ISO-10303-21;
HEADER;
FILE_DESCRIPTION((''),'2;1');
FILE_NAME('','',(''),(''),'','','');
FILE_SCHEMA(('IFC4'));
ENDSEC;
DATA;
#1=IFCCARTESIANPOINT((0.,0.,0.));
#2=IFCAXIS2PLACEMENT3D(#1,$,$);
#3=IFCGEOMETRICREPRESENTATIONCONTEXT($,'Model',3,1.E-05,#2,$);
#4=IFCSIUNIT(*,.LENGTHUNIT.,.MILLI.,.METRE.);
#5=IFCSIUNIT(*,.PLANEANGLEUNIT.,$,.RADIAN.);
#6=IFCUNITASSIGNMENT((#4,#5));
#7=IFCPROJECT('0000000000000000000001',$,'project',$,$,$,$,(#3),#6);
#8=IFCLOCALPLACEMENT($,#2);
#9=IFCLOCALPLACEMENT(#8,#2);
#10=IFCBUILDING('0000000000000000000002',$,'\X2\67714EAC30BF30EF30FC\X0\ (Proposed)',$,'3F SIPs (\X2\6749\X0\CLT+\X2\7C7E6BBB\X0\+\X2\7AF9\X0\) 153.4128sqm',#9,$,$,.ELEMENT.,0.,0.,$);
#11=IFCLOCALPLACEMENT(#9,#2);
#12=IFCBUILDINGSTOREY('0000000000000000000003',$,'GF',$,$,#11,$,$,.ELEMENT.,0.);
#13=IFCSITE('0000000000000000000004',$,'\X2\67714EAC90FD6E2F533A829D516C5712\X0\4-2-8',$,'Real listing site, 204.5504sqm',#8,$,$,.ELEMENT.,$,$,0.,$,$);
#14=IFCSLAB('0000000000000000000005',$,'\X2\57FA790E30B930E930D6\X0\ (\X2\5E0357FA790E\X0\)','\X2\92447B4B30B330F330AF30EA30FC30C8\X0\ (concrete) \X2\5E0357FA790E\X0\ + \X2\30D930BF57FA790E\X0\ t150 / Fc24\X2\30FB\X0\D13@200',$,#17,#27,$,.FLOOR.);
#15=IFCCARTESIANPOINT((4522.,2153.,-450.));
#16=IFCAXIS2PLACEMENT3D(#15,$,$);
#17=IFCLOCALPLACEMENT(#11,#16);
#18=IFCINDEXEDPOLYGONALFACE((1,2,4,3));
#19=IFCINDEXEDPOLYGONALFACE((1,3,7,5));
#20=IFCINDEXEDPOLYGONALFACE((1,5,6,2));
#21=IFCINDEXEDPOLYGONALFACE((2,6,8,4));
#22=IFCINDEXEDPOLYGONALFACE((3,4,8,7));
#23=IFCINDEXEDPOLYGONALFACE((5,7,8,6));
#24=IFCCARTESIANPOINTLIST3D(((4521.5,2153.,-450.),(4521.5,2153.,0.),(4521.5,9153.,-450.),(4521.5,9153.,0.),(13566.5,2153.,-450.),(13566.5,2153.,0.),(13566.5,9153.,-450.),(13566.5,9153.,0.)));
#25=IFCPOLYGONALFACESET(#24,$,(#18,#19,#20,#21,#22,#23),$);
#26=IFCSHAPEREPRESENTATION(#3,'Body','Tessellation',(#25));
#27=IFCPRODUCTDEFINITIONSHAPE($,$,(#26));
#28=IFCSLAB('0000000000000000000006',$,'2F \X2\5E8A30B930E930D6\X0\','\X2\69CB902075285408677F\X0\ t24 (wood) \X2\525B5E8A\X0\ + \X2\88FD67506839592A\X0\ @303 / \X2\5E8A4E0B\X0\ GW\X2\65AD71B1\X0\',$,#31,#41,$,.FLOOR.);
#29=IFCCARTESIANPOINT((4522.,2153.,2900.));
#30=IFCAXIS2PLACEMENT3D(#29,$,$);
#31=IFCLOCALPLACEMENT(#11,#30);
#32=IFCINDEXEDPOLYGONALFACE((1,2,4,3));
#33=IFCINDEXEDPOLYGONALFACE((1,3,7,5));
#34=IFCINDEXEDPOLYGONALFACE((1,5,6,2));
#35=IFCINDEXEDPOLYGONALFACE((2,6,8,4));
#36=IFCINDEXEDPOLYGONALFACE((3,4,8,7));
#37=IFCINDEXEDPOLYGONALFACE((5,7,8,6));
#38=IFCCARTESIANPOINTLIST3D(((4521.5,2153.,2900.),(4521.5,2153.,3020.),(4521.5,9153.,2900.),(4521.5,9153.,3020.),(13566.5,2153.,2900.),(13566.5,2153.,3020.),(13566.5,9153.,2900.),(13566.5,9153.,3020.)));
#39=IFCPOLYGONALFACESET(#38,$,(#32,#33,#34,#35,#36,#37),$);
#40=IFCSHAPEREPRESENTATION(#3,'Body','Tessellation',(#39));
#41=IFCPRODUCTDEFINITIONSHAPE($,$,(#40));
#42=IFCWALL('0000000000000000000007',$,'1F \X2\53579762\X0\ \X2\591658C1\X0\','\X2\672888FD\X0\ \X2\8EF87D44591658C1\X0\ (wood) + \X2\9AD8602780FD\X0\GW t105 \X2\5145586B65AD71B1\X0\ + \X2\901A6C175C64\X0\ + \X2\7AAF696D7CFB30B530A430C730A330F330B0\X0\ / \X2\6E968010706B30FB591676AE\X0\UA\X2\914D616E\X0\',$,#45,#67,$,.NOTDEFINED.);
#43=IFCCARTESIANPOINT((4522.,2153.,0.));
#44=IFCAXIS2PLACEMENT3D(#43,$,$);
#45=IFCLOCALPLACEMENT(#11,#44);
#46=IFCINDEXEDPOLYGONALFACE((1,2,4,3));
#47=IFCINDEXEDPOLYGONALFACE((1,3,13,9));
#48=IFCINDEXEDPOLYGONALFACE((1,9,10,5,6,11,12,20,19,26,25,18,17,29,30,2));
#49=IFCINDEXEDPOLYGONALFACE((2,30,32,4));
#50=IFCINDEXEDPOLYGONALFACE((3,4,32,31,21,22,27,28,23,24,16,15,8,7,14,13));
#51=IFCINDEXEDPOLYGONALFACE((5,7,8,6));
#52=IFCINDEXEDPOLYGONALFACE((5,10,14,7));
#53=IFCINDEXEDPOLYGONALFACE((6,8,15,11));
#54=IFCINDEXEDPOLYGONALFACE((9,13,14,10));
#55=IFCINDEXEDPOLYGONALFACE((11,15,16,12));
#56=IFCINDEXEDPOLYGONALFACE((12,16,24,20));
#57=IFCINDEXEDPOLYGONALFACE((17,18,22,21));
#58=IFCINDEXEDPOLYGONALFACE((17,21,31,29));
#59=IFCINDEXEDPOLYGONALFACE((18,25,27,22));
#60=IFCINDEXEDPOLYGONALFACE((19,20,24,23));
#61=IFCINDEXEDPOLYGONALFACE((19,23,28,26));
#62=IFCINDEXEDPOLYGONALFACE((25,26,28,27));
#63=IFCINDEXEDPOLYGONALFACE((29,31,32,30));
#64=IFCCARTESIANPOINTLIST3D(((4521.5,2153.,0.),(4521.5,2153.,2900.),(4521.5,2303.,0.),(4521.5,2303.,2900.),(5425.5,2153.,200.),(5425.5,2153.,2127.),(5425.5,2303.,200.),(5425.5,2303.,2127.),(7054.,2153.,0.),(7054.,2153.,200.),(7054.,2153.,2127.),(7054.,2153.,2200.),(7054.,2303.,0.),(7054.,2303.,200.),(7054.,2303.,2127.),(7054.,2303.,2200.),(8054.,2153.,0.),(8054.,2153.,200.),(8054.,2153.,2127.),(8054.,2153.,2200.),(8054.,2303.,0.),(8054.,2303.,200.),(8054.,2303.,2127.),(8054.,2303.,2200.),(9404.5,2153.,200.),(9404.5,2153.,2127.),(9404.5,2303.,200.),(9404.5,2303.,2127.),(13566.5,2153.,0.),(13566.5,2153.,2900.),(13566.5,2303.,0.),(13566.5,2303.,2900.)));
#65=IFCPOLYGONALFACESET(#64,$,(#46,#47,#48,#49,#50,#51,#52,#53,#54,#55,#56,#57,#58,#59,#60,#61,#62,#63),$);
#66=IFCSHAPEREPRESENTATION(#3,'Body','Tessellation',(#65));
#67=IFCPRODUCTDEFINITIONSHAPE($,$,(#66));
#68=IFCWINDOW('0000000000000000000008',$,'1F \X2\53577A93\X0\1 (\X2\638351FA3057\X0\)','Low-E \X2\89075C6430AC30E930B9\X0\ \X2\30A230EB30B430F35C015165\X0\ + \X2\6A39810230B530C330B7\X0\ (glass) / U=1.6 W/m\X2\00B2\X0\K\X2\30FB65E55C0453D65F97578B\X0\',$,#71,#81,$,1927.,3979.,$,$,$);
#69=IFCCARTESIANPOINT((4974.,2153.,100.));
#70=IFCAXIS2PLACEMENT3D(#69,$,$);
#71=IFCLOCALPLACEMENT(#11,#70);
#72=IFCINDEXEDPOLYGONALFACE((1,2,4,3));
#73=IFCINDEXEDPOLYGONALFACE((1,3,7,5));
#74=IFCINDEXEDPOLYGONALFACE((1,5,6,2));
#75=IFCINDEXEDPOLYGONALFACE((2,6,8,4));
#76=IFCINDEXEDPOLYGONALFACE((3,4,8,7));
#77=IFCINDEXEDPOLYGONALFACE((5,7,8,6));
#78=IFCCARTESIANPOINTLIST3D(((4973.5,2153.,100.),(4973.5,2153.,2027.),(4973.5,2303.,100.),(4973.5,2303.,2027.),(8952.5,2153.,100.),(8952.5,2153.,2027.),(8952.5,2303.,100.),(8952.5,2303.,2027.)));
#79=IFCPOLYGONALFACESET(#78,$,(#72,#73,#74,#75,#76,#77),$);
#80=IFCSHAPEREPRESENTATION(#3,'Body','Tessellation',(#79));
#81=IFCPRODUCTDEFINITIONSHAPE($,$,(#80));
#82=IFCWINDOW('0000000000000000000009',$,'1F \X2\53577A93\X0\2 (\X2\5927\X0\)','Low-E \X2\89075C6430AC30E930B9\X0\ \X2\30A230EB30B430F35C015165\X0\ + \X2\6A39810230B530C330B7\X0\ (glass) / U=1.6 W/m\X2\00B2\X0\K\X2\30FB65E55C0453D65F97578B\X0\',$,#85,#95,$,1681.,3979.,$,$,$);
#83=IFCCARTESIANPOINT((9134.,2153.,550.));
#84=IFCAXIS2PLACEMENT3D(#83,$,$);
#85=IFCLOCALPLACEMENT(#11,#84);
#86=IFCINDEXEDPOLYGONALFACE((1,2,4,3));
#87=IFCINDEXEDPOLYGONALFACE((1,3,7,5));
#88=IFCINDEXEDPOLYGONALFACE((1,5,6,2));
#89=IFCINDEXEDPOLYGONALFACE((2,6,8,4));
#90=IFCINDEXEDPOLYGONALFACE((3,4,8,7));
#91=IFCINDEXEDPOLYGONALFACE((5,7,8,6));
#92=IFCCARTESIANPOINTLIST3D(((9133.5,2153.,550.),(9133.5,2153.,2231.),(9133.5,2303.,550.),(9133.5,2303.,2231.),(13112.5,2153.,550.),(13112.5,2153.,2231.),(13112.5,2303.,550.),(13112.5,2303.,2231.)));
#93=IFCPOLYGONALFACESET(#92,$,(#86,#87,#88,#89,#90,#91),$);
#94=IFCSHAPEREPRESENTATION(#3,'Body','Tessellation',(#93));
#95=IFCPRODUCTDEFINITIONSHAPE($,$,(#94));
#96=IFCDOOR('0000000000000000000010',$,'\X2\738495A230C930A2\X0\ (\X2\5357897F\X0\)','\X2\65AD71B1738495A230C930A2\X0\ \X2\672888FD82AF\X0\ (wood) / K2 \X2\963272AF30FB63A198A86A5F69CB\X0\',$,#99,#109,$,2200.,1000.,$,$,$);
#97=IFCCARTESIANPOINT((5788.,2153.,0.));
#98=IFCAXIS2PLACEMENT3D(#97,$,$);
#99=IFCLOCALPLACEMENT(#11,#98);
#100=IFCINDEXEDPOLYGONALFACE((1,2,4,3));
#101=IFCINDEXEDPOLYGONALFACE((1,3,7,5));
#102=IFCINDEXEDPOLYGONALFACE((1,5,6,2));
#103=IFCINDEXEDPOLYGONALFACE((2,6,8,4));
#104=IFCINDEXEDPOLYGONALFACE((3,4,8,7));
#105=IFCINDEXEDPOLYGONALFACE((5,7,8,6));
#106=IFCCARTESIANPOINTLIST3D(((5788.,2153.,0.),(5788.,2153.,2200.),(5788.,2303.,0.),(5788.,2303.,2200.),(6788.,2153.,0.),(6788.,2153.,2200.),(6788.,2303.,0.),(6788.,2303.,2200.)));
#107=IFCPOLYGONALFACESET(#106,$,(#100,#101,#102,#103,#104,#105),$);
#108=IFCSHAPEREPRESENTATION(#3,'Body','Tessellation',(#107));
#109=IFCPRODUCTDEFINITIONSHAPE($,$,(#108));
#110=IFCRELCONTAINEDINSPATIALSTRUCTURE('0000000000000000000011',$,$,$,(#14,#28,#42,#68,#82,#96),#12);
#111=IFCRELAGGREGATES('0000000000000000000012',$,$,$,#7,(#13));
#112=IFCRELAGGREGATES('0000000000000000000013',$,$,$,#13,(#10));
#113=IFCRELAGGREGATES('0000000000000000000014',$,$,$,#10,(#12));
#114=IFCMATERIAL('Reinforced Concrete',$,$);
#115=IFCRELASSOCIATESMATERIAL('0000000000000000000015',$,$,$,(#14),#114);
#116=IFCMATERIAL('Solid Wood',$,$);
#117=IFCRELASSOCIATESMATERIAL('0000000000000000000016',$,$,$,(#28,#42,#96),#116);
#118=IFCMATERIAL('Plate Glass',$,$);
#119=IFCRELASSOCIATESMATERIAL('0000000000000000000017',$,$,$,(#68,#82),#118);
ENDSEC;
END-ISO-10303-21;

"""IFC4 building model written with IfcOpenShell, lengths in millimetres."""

from ifc_helpers import new_model, si_unit, frame, frame_2d, origin, place, context, project, spatial, rectangle, extrude, material, element, fill, save


model = new_model("IFC4")

# Units and contexts
model_context = context("Model", 3, precision=1e-05, world=origin())
ifc_project = project(units=[si_unit("LENGTHUNIT", "METRE", prefix="MILLI"), si_unit("PLANEANGLEUNIT", "RADIAN")], contexts=[model_context])

# Site, building, storey
site_placement = place(None, origin())
site = spatial("IfcSite", under=ifc_project, at=site_placement, Name="東京都港区芝公園4-2-8", ObjectType="Real listing site, 204.5504sqm", CompositionType="ELEMENT", RefElevation=0.0)
building_placement = place(site_placement, origin())
building = spatial("IfcBuilding", under=site, at=building_placement, Name="東京タワー (Proposed)", ObjectType="3F SIPs (杉CLT+籾殻+竹) 153.4128sqm", CompositionType="ELEMENT", ElevationOfRefHeight=0.0, ElevationOfTerrain=0.0)
storey_placement = place(building_placement, origin())
storey = spatial("IfcBuildingStorey", under=building, at=storey_placement, Name="GF", CompositionType="ELEMENT", Elevation=0.0)

# Slabs
ifc_material_1 = material(Name="Reinforced Concrete")
slab_1_placement = place(storey_placement, frame((4522.0, 2153.0, -450.0)))
element("IfcSlab", 1, at=slab_1_placement, inside=storey, material=ifc_material_1, Name="基礎スラブ (布基礎)", Description="鉄筋コンクリート (concrete) 布基礎 + ベタ基礎 t150 / Fc24・D13@200", PredefinedType="FLOOR", context=model_context, shape_type="SweptSolid", body=[
    extrude(rectangle(XDim=9045.0, YDim=7000.0, at=frame_2d((4522.0, 3500.0))), frame((4522.0, 2153.0, -450.0)), (0.0, 0.0, 1.0), 450.0),
])
ifc_material_2 = material(Name="Solid Wood")
slab_2_placement = place(storey_placement, frame((4522.0, 2153.0, 2900.0)))
element("IfcSlab", 2, at=slab_2_placement, inside=storey, material=ifc_material_2, Name="2F 床スラブ", Description="構造用合板 t24 (wood) 剛床 + 製材根太 @303 / 床下 GW断熱", PredefinedType="FLOOR", context=model_context, shape_type="SweptSolid", body=[
    extrude(rectangle(XDim=9045.0, YDim=7000.0, at=frame_2d((4522.0, 3500.0))), frame((4522.0, 2153.0, 2900.0)), (0.0, 0.0, 1.0), 120.0),
])

# Wall, openings, windows, door
wall_1_placement = place(storey_placement, frame((4522.0, 2153.0, 0.0)))
wall_1 = element("IfcWall", 3, at=wall_1_placement, inside=storey, material=ifc_material_2, Name="1F 南面 外壁", Description="木製 軸組外壁 (wood) + 高性能GW t105 充填断熱 + 通気層 + 窯業系サイディング / 準耐火・外皮UA配慮", PredefinedType="NOTDEFINED", context=model_context, shape_type="SweptSolid", body=[
    extrude(rectangle(XDim=9045.0, YDim=150.0, at=frame_2d((4522.0, 75.0))), frame((4522.0, 2153.0, 0.0)), (0.0, 0.0, 1.0), 2900.0),
])
opening_1_placement = place(storey_placement, frame((4974.0, 2153.0, 100.0)))
opening_1 = element("IfcOpeningElement", 4, at=opening_1_placement, cuts=wall_1, PredefinedType="NOTDEFINED", context=model_context, shape_type="SweptSolid", body=[
    extrude(rectangle(XDim=3979.0, YDim=150.0, at=frame_2d((1989.0, 75.0))), frame((4974.0, 2153.0, 100.0)), (0.0, 0.0, 1.0), 1927.0),
])
opening_2_placement = place(storey_placement, frame((9134.0, 2153.0, 550.0)))
opening_2 = element("IfcOpeningElement", 5, at=opening_2_placement, cuts=wall_1, PredefinedType="NOTDEFINED", context=model_context, shape_type="SweptSolid", body=[
    extrude(rectangle(XDim=3979.0, YDim=150.0, at=frame_2d((1989.0, 75.0))), frame((9134.0, 2153.0, 550.0)), (0.0, 0.0, 1.0), 1681.0),
])
opening_3_placement = place(storey_placement, frame((5788.0, 2153.0, 0.0)))
opening_3 = element("IfcOpeningElement", 6, at=opening_3_placement, cuts=wall_1, PredefinedType="NOTDEFINED", context=model_context, shape_type="SweptSolid", body=[
    extrude(rectangle(XDim=1000.0, YDim=150.0, at=frame_2d((500.0, 75.0))), frame((5788.0, 2153.0, 0.0)), (0.0, 0.0, 1.0), 2200.0),
])
ifc_material_3 = material(Name="Plate Glass")
window_1_placement = place(storey_placement, frame((4974.0, 2153.0, 100.0)))
window_1 = element("IfcWindow", 7, at=window_1_placement, inside=storey, material=ifc_material_3, Name="1F 南窓1 (掃出し)", Description="Low-E 複層ガラス アルゴン封入 + 樹脂サッシ (glass) / U=1.6 W/m²K・日射取得型", OverallHeight=1927.0, OverallWidth=3979.0, context=model_context, shape_type="SweptSolid", body=[
    extrude(rectangle(XDim=3979.0, YDim=150.0, at=frame_2d((1989.0, 75.0))), frame((4974.0, 2153.0, 100.0)), (0.0, 0.0, 1.0), 1927.0),
])
fill(opening_1, window_1)
window_2_placement = place(storey_placement, frame((9134.0, 2153.0, 550.0)))
window_2 = element("IfcWindow", 8, at=window_2_placement, inside=storey, material=ifc_material_3, Name="1F 南窓2 (大)", Description="Low-E 複層ガラス アルゴン封入 + 樹脂サッシ (glass) / U=1.6 W/m²K・日射取得型", OverallHeight=1681.0, OverallWidth=3979.0, context=model_context, shape_type="SweptSolid", body=[
    extrude(rectangle(XDim=3979.0, YDim=150.0, at=frame_2d((1989.0, 75.0))), frame((9134.0, 2153.0, 550.0)), (0.0, 0.0, 1.0), 1681.0),
])
fill(opening_2, window_2)
door_1_placement = place(storey_placement, frame((5788.0, 2153.0, 0.0)))
door_1 = element("IfcDoor", 9, at=door_1_placement, inside=storey, material=ifc_material_2, Name="玄関ドア (南西)", Description="断熱玄関ドア 木製芯 (wood) / K2 防犯・採風機構", OverallHeight=2200.0, OverallWidth=1000.0, context=model_context, shape_type="SweptSolid", body=[
    extrude(rectangle(XDim=1000.0, YDim=150.0, at=frame_2d((500.0, 75.0))), frame((5788.0, 2153.0, 0.0)), (0.0, 0.0, 1.0), 2200.0),
])
fill(opening_3, door_1)

save(model, "model.ifc")
